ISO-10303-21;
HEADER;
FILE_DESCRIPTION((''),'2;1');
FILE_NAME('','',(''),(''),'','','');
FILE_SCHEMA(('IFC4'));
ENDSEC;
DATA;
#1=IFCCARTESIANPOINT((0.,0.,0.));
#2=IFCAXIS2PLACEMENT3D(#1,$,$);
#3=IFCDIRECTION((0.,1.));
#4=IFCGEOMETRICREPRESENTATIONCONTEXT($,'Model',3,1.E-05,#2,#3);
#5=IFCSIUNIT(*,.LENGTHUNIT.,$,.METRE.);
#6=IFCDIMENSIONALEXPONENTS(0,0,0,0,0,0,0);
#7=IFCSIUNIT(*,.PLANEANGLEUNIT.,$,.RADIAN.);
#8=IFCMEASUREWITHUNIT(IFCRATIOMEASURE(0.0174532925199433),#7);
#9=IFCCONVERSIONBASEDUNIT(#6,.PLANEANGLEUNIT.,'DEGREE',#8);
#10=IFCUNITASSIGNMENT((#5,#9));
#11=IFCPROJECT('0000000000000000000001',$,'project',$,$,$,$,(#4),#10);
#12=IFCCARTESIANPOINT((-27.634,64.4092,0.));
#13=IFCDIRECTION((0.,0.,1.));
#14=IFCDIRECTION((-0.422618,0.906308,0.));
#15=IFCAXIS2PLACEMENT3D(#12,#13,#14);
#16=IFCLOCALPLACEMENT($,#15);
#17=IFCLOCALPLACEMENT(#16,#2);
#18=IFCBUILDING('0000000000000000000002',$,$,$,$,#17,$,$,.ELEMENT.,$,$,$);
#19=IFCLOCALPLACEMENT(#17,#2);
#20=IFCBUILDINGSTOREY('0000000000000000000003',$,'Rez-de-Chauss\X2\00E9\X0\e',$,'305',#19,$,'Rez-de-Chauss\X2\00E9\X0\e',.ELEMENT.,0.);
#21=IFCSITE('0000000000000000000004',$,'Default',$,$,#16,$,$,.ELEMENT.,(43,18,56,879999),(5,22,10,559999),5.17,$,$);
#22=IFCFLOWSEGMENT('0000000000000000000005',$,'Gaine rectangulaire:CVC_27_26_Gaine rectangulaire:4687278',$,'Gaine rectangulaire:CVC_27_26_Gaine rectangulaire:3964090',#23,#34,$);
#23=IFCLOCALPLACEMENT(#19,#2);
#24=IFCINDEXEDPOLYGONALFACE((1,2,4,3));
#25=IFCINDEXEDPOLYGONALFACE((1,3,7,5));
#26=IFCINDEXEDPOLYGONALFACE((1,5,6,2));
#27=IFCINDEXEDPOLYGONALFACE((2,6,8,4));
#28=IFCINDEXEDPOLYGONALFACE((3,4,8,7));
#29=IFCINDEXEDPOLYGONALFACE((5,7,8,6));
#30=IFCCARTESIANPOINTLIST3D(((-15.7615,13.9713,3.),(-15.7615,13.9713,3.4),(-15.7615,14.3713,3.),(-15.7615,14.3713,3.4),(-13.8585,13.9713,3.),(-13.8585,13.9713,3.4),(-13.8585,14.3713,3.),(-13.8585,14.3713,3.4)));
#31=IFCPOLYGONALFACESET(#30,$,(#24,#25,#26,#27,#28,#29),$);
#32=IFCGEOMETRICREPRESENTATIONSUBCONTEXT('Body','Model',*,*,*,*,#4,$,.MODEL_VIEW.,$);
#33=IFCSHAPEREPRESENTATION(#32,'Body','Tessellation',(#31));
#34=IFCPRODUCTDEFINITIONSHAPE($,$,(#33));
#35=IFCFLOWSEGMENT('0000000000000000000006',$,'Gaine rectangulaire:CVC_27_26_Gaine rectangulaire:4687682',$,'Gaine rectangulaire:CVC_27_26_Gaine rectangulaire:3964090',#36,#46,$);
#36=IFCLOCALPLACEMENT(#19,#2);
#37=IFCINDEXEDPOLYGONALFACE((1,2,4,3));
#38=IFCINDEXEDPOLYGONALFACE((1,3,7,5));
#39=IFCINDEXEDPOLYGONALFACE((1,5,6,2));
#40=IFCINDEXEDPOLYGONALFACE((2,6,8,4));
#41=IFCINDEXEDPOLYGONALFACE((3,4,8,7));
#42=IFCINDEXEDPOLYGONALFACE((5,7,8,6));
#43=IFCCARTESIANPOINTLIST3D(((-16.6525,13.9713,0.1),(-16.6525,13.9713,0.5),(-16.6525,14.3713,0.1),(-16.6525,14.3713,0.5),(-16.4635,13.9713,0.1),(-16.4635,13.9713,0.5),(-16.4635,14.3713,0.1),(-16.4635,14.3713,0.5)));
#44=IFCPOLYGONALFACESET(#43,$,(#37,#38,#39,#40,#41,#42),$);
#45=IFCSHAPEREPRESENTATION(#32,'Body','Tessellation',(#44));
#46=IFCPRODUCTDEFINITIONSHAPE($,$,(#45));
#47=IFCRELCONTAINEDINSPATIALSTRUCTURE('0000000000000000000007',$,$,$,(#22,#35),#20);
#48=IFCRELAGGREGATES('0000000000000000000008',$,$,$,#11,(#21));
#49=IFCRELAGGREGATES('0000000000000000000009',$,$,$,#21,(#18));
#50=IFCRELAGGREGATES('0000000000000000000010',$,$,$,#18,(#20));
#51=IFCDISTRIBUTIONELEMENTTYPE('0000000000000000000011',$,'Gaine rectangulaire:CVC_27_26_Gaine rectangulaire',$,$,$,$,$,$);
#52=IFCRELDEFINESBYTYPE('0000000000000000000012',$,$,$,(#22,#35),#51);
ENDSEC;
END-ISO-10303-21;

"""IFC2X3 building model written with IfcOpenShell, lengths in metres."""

from ifc_helpers import new_model, entity, si_unit, converted_unit, direction, frame, frame_2d, origin, place, context, subcontext, project, spatial, rectangle, extrude, type_object, element, save


model = new_model("IFC2X3")

# Units and contexts
model_context = context("Model", 3, precision=1e-05, world=origin(), true_north=direction((0.0, 1.0)))
body_context = subcontext(model_context, "Body", "Model", "MODEL_VIEW")
ifc_project = project(units=[si_unit("LENGTHUNIT", "METRE"), converted_unit("PLANEANGLEUNIT", "DEGREE", entity("IfcRatioMeasure", 0.0174532925199433), si_unit("PLANEANGLEUNIT", "RADIAN"), dimensions=[0, 0, 0, 0, 0, 0, 0])], contexts=[model_context])

# Site, building, storey
site_placement = place(None, frame((-27.634, 64.4092, 0.0), z_axis=(0.0, 0.0, 1.0), x_axis=(-0.422618, 0.906308, 0.0)))
site = spatial("IfcSite", under=ifc_project, at=site_placement, Name="Default", CompositionType="ELEMENT", RefLatitude=(43, 18, 56, 879999), RefLongitude=(5, 22, 10, 559999), RefElevation=5.17)
building_placement = place(site_placement, origin())
building = spatial("IfcBuilding", under=site, at=building_placement, CompositionType="ELEMENT")
storey_placement = place(building_placement, origin())
storey = spatial("IfcBuildingStorey", under=building, at=storey_placement, Name="Rez-de-Chaussée", ObjectType="305", LongName="Rez-de-Chaussée", CompositionType="ELEMENT", Elevation=0.0)

# Flow segments
distribution_element_type = type_object("IfcDistributionElementType", Name="Gaine rectangulaire:CVC_27_26_Gaine rectangulaire")
flow_segment_1_placement = place(storey_placement, origin())
element("IfcFlowSegment", 1, at=flow_segment_1_placement, inside=storey, type_object=distribution_element_type, Name="Gaine rectangulaire:CVC_27_26_Gaine rectangulaire:4687278", ObjectType="Gaine rectangulaire:CVC_27_26_Gaine rectangulaire:3964090", context=body_context, shape_type="SweptSolid", body=[
    extrude(rectangle(XDim=1.903, YDim=0.4, at=frame_2d((0.0, 0.0), x_axis=(1.0, 0.0))), frame((-14.81, 14.1713, 3.0)), (0.0, 0.0, 1.0), 0.4),
])
flow_segment_2_placement = place(storey_placement, origin())
element("IfcFlowSegment", 2, at=flow_segment_2_placement, inside=storey, type_object=distribution_element_type, Name="Gaine rectangulaire:CVC_27_26_Gaine rectangulaire:4687682", ObjectType="Gaine rectangulaire:CVC_27_26_Gaine rectangulaire:3964090", context=body_context, shape_type="SweptSolid", body=[
    extrude(rectangle(XDim=0.189, YDim=0.4, at=frame_2d((0.0, 0.0), x_axis=(1.0, 0.0))), frame((-16.558, 14.1713, 0.1), z_axis=(0.0, 0.0, 1.0), x_axis=(-1.0, 0.0, 0.0)), (0.0, 0.0, 1.0), 0.4),
])

save(model, "model.ifc")
